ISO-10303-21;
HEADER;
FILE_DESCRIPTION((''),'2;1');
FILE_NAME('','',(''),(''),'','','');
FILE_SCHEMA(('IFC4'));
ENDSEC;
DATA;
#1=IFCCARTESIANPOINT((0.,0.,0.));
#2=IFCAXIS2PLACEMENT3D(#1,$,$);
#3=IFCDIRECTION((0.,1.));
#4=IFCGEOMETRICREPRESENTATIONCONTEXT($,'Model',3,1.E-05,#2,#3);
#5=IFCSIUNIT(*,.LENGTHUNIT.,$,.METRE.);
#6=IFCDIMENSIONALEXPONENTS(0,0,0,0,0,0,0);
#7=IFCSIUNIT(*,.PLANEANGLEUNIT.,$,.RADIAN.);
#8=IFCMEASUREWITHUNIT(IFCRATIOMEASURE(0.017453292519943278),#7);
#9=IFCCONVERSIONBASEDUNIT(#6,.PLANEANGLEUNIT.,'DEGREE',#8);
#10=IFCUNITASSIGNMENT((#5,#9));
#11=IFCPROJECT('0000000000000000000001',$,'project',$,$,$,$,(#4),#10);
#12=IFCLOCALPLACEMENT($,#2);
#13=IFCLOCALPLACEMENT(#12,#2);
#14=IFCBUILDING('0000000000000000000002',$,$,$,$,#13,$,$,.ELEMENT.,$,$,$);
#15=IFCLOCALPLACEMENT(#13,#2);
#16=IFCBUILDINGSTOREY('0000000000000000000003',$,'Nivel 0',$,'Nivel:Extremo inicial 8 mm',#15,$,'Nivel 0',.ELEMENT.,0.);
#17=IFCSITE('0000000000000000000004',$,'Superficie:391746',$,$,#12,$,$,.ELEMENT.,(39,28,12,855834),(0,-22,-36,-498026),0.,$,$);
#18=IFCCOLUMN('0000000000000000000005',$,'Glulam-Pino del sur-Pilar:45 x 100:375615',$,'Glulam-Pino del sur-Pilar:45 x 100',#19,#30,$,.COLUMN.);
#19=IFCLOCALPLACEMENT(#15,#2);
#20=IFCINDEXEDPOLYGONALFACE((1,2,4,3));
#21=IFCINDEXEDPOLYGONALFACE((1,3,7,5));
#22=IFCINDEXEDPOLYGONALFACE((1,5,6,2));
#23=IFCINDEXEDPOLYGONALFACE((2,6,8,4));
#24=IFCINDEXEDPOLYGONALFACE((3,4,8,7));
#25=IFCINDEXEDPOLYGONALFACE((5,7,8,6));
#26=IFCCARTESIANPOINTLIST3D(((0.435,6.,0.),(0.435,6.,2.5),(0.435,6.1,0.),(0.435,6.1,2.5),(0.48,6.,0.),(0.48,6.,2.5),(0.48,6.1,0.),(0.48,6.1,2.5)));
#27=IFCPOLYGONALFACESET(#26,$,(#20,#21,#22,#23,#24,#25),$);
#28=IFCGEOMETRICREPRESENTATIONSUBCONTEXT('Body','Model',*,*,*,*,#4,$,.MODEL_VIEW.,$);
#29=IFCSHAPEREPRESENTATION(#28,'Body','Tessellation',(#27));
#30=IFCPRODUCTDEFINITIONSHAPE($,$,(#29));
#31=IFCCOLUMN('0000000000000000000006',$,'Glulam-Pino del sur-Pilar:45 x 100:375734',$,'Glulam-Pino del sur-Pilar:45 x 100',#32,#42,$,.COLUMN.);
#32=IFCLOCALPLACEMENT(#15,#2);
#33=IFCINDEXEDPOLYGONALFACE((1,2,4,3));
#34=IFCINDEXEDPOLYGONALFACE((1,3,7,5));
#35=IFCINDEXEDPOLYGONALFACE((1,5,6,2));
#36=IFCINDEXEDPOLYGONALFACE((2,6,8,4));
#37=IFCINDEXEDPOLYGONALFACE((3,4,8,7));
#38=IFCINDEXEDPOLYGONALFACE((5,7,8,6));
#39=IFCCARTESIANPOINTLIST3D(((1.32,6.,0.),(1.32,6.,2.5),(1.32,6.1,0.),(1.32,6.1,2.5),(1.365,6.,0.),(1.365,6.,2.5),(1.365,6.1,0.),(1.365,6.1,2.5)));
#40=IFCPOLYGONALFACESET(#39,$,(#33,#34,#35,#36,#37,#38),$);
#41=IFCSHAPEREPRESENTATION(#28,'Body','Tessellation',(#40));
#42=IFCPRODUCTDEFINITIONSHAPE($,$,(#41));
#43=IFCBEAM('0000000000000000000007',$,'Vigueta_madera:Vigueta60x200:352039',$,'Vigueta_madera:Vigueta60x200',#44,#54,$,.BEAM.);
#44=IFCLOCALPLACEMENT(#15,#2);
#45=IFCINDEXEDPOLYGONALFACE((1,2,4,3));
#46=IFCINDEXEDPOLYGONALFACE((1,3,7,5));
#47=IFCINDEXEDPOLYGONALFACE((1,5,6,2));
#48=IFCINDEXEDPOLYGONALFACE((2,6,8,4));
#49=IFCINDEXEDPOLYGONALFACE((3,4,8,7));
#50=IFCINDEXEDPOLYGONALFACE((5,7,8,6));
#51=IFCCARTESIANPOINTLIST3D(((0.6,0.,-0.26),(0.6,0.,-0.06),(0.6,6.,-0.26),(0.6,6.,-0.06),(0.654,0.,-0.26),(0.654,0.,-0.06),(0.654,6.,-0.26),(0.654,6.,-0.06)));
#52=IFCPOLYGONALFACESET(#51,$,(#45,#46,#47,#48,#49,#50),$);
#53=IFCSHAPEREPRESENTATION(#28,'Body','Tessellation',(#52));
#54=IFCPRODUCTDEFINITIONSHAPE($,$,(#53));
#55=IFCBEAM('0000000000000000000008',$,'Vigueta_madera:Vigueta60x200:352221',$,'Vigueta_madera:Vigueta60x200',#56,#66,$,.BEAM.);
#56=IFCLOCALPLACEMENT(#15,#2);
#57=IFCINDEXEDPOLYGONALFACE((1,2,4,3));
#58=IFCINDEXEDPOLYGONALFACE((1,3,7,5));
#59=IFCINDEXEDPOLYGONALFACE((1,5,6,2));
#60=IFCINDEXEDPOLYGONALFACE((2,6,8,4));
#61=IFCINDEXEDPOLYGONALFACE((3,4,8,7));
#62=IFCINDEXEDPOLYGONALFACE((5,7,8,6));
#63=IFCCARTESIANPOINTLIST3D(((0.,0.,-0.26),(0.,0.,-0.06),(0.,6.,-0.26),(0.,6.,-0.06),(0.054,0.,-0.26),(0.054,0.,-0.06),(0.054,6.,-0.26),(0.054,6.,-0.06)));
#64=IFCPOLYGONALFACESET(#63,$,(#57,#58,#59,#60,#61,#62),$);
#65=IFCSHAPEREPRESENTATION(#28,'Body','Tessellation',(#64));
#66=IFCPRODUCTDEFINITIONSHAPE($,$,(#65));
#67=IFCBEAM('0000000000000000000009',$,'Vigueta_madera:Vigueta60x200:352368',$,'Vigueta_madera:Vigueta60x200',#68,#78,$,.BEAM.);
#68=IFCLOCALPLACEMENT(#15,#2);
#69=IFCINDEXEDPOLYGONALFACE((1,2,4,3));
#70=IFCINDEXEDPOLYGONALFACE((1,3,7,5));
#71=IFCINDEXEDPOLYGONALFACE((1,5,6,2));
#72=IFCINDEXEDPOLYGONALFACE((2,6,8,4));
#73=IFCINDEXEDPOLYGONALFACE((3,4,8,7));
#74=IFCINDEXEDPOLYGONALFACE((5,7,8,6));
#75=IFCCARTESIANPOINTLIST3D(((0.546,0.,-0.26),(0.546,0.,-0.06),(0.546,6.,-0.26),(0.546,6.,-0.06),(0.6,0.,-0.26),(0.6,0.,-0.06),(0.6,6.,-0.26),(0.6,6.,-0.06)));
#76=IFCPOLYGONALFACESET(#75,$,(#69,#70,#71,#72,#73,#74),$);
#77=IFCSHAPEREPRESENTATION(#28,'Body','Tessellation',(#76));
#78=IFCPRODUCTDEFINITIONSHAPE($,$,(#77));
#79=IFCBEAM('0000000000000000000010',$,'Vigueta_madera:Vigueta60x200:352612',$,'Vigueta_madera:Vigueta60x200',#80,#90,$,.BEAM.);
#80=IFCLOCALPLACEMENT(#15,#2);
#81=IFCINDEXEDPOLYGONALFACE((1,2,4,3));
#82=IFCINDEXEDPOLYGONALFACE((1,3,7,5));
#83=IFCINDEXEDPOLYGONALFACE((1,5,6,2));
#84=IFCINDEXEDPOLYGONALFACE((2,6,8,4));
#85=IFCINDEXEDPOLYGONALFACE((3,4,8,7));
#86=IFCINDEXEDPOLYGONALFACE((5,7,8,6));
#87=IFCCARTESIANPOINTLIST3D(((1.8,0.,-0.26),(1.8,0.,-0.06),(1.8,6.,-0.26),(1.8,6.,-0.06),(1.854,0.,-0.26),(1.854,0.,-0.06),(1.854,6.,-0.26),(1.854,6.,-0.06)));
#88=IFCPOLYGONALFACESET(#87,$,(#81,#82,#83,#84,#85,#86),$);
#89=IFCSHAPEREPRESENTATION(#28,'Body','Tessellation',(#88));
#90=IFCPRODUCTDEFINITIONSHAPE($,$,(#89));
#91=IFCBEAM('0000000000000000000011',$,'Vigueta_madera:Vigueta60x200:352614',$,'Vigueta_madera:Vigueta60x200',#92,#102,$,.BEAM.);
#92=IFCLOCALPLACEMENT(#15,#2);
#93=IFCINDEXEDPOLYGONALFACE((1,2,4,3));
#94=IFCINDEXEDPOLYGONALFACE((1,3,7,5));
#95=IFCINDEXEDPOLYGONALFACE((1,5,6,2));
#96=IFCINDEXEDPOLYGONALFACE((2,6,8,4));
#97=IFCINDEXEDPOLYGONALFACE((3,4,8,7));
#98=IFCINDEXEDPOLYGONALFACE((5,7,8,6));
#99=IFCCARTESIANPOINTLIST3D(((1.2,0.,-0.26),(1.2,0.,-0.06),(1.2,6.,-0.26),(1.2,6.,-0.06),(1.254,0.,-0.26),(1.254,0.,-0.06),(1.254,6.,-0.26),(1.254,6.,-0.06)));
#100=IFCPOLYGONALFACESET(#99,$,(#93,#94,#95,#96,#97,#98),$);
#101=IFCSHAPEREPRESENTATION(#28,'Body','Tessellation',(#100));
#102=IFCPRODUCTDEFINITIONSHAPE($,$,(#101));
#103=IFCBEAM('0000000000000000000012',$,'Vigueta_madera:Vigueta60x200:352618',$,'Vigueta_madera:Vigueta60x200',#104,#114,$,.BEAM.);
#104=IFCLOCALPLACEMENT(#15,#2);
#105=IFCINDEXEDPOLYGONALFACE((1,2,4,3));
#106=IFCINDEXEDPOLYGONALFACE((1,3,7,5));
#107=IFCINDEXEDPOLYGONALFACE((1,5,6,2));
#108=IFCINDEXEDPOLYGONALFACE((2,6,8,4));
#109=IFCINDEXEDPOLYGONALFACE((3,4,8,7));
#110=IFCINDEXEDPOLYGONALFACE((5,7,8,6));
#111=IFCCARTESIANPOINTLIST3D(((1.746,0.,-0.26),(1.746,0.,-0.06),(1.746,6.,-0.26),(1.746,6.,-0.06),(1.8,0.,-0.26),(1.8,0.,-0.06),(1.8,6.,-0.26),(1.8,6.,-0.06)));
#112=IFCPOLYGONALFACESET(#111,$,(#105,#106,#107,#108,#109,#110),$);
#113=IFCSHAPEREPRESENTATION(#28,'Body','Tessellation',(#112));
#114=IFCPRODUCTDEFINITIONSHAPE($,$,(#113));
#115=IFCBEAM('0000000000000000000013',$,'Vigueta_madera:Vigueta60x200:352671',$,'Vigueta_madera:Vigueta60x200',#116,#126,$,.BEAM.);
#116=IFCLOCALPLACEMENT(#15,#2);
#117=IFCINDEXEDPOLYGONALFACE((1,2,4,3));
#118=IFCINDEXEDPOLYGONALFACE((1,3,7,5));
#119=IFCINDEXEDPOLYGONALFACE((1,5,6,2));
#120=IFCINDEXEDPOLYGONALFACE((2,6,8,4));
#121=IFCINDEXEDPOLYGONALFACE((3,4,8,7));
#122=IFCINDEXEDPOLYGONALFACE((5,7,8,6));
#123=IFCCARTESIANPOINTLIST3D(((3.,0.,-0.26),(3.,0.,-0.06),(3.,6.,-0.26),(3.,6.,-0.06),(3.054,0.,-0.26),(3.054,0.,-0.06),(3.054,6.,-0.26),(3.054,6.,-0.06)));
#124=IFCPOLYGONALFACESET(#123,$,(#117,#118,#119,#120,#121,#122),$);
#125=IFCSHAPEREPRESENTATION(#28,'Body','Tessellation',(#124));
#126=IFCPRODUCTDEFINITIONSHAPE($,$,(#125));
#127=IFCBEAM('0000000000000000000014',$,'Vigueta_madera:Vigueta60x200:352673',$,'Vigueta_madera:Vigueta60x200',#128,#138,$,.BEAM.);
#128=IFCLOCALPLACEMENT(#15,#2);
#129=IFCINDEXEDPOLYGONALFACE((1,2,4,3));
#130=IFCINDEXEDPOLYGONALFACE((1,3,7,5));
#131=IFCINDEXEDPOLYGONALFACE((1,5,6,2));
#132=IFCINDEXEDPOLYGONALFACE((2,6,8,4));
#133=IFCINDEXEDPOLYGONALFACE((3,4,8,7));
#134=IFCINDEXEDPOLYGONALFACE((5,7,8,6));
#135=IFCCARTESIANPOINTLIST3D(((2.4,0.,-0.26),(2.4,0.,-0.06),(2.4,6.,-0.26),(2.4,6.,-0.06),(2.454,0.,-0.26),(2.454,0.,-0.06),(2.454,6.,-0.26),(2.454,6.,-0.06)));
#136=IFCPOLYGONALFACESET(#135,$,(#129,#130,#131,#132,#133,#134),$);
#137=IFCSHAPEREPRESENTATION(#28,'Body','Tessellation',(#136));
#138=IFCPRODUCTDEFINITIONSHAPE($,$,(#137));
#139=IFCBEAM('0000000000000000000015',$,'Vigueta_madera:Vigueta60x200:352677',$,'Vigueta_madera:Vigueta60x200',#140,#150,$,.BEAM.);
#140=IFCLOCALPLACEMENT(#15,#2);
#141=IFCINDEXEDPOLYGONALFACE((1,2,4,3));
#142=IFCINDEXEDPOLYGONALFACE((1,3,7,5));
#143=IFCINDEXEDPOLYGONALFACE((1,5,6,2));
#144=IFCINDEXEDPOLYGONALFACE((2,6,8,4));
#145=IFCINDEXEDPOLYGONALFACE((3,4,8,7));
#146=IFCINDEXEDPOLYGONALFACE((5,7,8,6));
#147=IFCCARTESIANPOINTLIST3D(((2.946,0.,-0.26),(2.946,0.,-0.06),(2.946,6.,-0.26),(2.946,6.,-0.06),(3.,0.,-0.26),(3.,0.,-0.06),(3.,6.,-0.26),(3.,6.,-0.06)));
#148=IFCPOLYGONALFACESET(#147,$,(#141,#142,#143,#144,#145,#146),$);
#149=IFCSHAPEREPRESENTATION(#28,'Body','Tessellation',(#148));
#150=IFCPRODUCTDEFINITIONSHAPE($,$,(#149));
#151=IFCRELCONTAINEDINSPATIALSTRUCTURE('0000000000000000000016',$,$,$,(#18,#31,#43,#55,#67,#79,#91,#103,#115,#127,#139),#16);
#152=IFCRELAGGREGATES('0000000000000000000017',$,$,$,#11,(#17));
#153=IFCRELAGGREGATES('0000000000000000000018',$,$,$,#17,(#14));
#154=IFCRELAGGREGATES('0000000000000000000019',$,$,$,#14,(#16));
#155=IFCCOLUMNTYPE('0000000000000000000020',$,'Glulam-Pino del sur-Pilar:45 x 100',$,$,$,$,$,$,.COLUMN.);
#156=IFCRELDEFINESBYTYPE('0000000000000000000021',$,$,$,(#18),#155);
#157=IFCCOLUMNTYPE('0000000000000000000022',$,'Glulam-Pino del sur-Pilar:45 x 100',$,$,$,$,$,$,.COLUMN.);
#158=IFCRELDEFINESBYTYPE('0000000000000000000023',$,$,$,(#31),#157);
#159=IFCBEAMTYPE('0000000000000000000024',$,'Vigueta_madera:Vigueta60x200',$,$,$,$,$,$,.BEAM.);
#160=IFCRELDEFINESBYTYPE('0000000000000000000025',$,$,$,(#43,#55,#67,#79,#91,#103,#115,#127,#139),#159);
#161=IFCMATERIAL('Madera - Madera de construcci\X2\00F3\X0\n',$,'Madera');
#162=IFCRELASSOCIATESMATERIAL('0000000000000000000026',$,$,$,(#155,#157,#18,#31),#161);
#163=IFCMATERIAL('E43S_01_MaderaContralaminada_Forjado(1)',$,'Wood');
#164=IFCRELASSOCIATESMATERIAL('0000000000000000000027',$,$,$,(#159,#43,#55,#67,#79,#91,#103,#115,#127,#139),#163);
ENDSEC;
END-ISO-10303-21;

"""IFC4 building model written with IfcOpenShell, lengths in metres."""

from ifc_helpers import new_model, entity, si_unit, converted_unit, direction, frame, origin, origin_2d_with_axis, place, context, subcontext, project, spatial, polyline, segment, composite_curve, rectangle, outline, extrude, source, transform, mapped, material, material_profile, profile_set, profile_usage, type_object, type_shapes, element, save


model = new_model("IFC4")

# Units and contexts
model_context = context("Model", 3, precision=1e-05, world=origin(), true_north=direction((0.0, 1.0)))
body_context = subcontext(model_context, "Body", "Model", "MODEL_VIEW")
ifc_project = project(units=[si_unit("LENGTHUNIT", "METRE"), converted_unit("PLANEANGLEUNIT", "DEGREE", entity("IfcRatioMeasure", 0.017453292519943278), si_unit("PLANEANGLEUNIT", "RADIAN"), dimensions=[0, 0, 0, 0, 0, 0, 0])], contexts=[model_context])

# Site, building, storey
site_placement = place(None, origin())
site = spatial("IfcSite", under=ifc_project, at=site_placement, Name="Superficie:391746", CompositionType="ELEMENT", RefLatitude=(39, 28, 12, 855834), RefLongitude=(0, -22, -36, -498026), RefElevation=0.0)
building_placement = place(site_placement, origin())
building = spatial("IfcBuilding", under=site, at=building_placement, CompositionType="ELEMENT")
storey_placement = place(building_placement, origin())
storey = spatial("IfcBuildingStorey", under=building, at=storey_placement, Name="Nivel 0", ObjectType="Nivel:Extremo inicial 8 mm", LongName="Nivel 0", CompositionType="ELEMENT", Elevation=0.0)

# Columns
ifc_material_1 = material(Name="Madera - Madera de construcción", Category="Madera")
ifc_material_profile_1 = material_profile(ifc_material_1, outline(composite_curve([segment(polyline([(0.0225, 0.05, 0.0), (0.0225, -0.05, 0.0)]), True, "CONTINUOUS"), segment(polyline([(0.0225, -0.05, 0.0), (-0.0225, -0.05, 0.0)]), True, "CONTINUOUS"), segment(polyline([(-0.0225, -0.05, 0.0), (-0.0225, 0.05, 0.0)]), True, "CONTINUOUS"), segment(polyline([(-0.0225, 0.05, 0.0), (0.0225, 0.05, 0.0)]), True, "CONTINUOUS")], self_intersect=False), kind="CURVE"), Name="45 x 100")
ifc_material_profile_2 = material_profile(ifc_material_1, outline(composite_curve([segment(polyline([(0.0225, 0.05, 2.5), (-0.0225, 0.05, 2.5)]), True, "CONTINUOUS"), segment(polyline([(-0.0225, 0.05, 2.5), (-0.0225, -0.05, 2.5)]), True, "CONTINUOUS"), segment(polyline([(-0.0225, -0.05, 2.5), (0.0225, -0.05, 2.5)]), True, "CONTINUOUS"), segment(polyline([(0.0225, -0.05, 2.5), (0.0225, 0.05, 2.5)]), True, "CONTINUOUS")], self_intersect=False), kind="CURVE"), Name="45 x 100")
ifc_profile_set_1 = profile_set([ifc_material_profile_1, ifc_material_profile_2], Name="45 x 100")
ifc_profile_usage_1 = profile_usage(ifc_profile_set_1)
column_type_1 = type_object("IfcColumnType", Name="Glulam-Pino del sur-Pilar:45 x 100", PredefinedType="COLUMN", material=ifc_profile_set_1)
shared_shape_1 = source(origin(), body_context, "Body", "SweptSolid", [
    extrude(rectangle(XDim=0.1, YDim=0.045, at=origin_2d_with_axis()), frame((0.0, 0.0, 0.0), z_axis=(0.0, 0.0, 1.0), x_axis=(0.0, -1.0, 0.0)), (0.0, 0.0, 1.0), 2.5),
])
type_shapes(column_type_1, [shared_shape_1])
column_1_placement = place(storey_placement, frame((0.4575, 6.05, 0.0)))
element("IfcColumn", 1, at=column_1_placement, inside=storey, type_object=column_type_1, material=ifc_profile_usage_1, Name="Glulam-Pino del sur-Pilar:45 x 100:375615", ObjectType="Glulam-Pino del sur-Pilar:45 x 100", PredefinedType="COLUMN", context=body_context, shape_type="MappedRepresentation", body=[
    mapped(shared_shape_1, transform((0.0, 0.0, 0.0), scale=1.0)),
])
ifc_profile_usage_2 = profile_usage(ifc_profile_set_1)
column_type_2 = type_object("IfcColumnType", Name="Glulam-Pino del sur-Pilar:45 x 100", PredefinedType="COLUMN", material=ifc_profile_set_1)
shared_shape_2 = source(origin(), body_context, "Body", "SweptSolid", [
    extrude(rectangle(XDim=0.1, YDim=0.045, at=origin_2d_with_axis()), frame((0.0, 0.0, 0.0), z_axis=(0.0, 0.0, 1.0), x_axis=(0.0, -1.0, 0.0)), (0.0, 0.0, 1.0), 2.5),
])
type_shapes(column_type_2, [shared_shape_2])
column_2_placement = place(storey_placement, frame((1.3425, 6.05, 0.0), z_axis=(0.0, 0.0, 1.0), x_axis=(-1.0, 0.0, 0.0)))
element("IfcColumn", 2, at=column_2_placement, inside=storey, type_object=column_type_2, material=ifc_profile_usage_2, Name="Glulam-Pino del sur-Pilar:45 x 100:375734", ObjectType="Glulam-Pino del sur-Pilar:45 x 100", PredefinedType="COLUMN", context=body_context, shape_type="MappedRepresentation", body=[
    mapped(shared_shape_2, transform((0.0, 0.0, 0.0), scale=1.0)),
])

# Beams
ifc_material_2 = material(Name="E43S_01_MaderaContralaminada_Forjado(1)", Category="Wood")
ifc_material_profile_3 = material_profile(ifc_material_2, outline(composite_curve([segment(polyline([(-0.027, -0.1, 0.0), (-0.027, 0.1, 0.0)]), True, "CONTINUOUS"), segment(polyline([(-0.027, 0.1, 0.0), (0.027, 0.1, 0.0)]), True, "CONTINUOUS"), segment(polyline([(0.027, 0.1, 0.0), (0.027, -0.1, 0.0)]), True, "CONTINUOUS"), segment(polyline([(0.027, -0.1, 0.0), (-0.027, -0.1, 0.0)]), True, "CONTINUOUS")], self_intersect=False), kind="CURVE"), Name="Vigueta60x200")
ifc_material_profile_4 = material_profile(ifc_material_2, outline(composite_curve([segment(polyline([(3.0, 0.027, 0.1), (3.0, 0.027, -0.1)]), True, "CONTINUOUS"), segment(polyline([(3.0, 0.027, -0.1), (-3.0, 0.027, -0.1)]), True, "CONTINUOUS"), segment(polyline([(-3.0, 0.027, -0.1), (-3.0, 0.027, 0.1)]), True, "CONTINUOUS"), segment(polyline([(-3.0, 0.027, 0.1), (3.0, 0.027, 0.1)]), True, "CONTINUOUS")], self_intersect=False), kind="CURVE"), Name="Vigueta60x200")
ifc_profile_set_2 = profile_set([ifc_material_profile_3, ifc_material_profile_4], Name="Vigueta60x200")
ifc_profile_usage_3 = profile_usage(ifc_profile_set_2, cardinal=8)
beam_type_1 = type_object("IfcBeamType", Name="Vigueta_madera:Vigueta60x200", PredefinedType="BEAM", material=ifc_profile_set_2)
shared_shape_3 = source(origin(), body_context, "Body", "SweptSolid", [
    extrude(rectangle(XDim=0.2, YDim=0.054, at=origin_2d_with_axis()), frame((-3.0, 0.0, 0.0), z_axis=(1.0, 0.0, 0.0), x_axis=(0.0, 0.0, -1.0)), (0.0, 0.0, 1.0), 6.0),
])
type_shapes(beam_type_1, [shared_shape_3])
beam_1_placement = place(storey_placement, frame((0.627, 3.0, -0.16), z_axis=(0.0, 0.0, 1.0), x_axis=(0.0, 1.0, 0.0)))
element("IfcBeam", 3, at=beam_1_placement, inside=storey, type_object=beam_type_1, material=ifc_profile_usage_3, Name="Vigueta_madera:Vigueta60x200:352039", ObjectType="Vigueta_madera:Vigueta60x200", PredefinedType="BEAM", context=body_context, shape_type="MappedRepresentation", body=[
    mapped(shared_shape_3, transform((0.0, 0.0, 0.0), scale=1.0)),
])
ifc_profile_usage_4 = profile_usage(ifc_profile_set_2, cardinal=8)
beam_2_placement = place(storey_placement, frame((0.027, 3.0, -0.16), z_axis=(0.0, 0.0, 1.0), x_axis=(0.0, 1.0, 0.0)))
element("IfcBeam", 4, at=beam_2_placement, inside=storey, type_object=beam_type_1, material=ifc_profile_usage_4, Name="Vigueta_madera:Vigueta60x200:352221", ObjectType="Vigueta_madera:Vigueta60x200", PredefinedType="BEAM", context=body_context, shape_type="MappedRepresentation", body=[
    mapped(shared_shape_3, transform((0.0, 0.0, 0.0), scale=1.0)),
])
ifc_profile_usage_5 = profile_usage(ifc_profile_set_2, cardinal=8)
beam_3_placement = place(storey_placement, frame((0.573, 3.0, -0.16), z_axis=(0.0, 0.0, 1.0), x_axis=(0.0, 1.0, 0.0)))
element("IfcBeam", 5, at=beam_3_placement, inside=storey, type_object=beam_type_1, material=ifc_profile_usage_5, Name="Vigueta_madera:Vigueta60x200:352368", ObjectType="Vigueta_madera:Vigueta60x200", PredefinedType="BEAM", context=body_context, shape_type="MappedRepresentation", body=[
    mapped(shared_shape_3, transform((0.0, 0.0, 0.0), scale=1.0)),
])
ifc_profile_usage_6 = profile_usage(ifc_profile_set_2, cardinal=8)
beam_4_placement = place(storey_placement, frame((1.827, 3.0, -0.16), z_axis=(0.0, 0.0, 1.0), x_axis=(0.0, 1.0, 0.0)))
element("IfcBeam", 6, at=beam_4_placement, inside=storey, type_object=beam_type_1, material=ifc_profile_usage_6, Name="Vigueta_madera:Vigueta60x200:352612", ObjectType="Vigueta_madera:Vigueta60x200", PredefinedType="BEAM", context=body_context, shape_type="MappedRepresentation", body=[
    mapped(shared_shape_3, transform((0.0, 0.0, 0.0), scale=1.0)),
])
ifc_profile_usage_7 = profile_usage(ifc_profile_set_2, cardinal=8)
beam_5_placement = place(storey_placement, frame((1.227, 3.0, -0.16), z_axis=(0.0, 0.0, 1.0), x_axis=(0.0, 1.0, 0.0)))
element("IfcBeam", 7, at=beam_5_placement, inside=storey, type_object=beam_type_1, material=ifc_profile_usage_7, Name="Vigueta_madera:Vigueta60x200:352614", ObjectType="Vigueta_madera:Vigueta60x200", PredefinedType="BEAM", context=body_context, shape_type="MappedRepresentation", body=[
    mapped(shared_shape_3, transform((0.0, 0.0, 0.0), scale=1.0)),
])
ifc_profile_usage_8 = profile_usage(ifc_profile_set_2, cardinal=8)
beam_6_placement = place(storey_placement, frame((1.773, 3.0, -0.16), z_axis=(0.0, 0.0, 1.0), x_axis=(0.0, 1.0, 0.0)))
element("IfcBeam", 8, at=beam_6_placement, inside=storey, type_object=beam_type_1, material=ifc_profile_usage_8, Name="Vigueta_madera:Vigueta60x200:352618", ObjectType="Vigueta_madera:Vigueta60x200", PredefinedType="BEAM", context=body_context, shape_type="MappedRepresentation", body=[
    mapped(shared_shape_3, transform((0.0, 0.0, 0.0), scale=1.0)),
])
ifc_profile_usage_9 = profile_usage(ifc_profile_set_2, cardinal=8)
beam_7_placement = place(storey_placement, frame((3.027, 3.0, -0.16), z_axis=(0.0, 0.0, 1.0), x_axis=(0.0, 1.0, 0.0)))
element("IfcBeam", 9, at=beam_7_placement, inside=storey, type_object=beam_type_1, material=ifc_profile_usage_9, Name="Vigueta_madera:Vigueta60x200:352671", ObjectType="Vigueta_madera:Vigueta60x200", PredefinedType="BEAM", context=body_context, shape_type="MappedRepresentation", body=[
    mapped(shared_shape_3, transform((0.0, 0.0, 0.0), scale=1.0)),
])
ifc_profile_usage_10 = profile_usage(ifc_profile_set_2, cardinal=8)
beam_8_placement = place(storey_placement, frame((2.427, 3.0, -0.16), z_axis=(0.0, 0.0, 1.0), x_axis=(0.0, 1.0, 0.0)))
element("IfcBeam", 10, at=beam_8_placement, inside=storey, type_object=beam_type_1, material=ifc_profile_usage_10, Name="Vigueta_madera:Vigueta60x200:352673", ObjectType="Vigueta_madera:Vigueta60x200", PredefinedType="BEAM", context=body_context, shape_type="MappedRepresentation", body=[
    mapped(shared_shape_3, transform((0.0, 0.0, 0.0), scale=1.0)),
])
ifc_profile_usage_11 = profile_usage(ifc_profile_set_2, cardinal=8)
beam_9_placement = place(storey_placement, frame((2.973, 3.0, -0.16), z_axis=(0.0, 0.0, 1.0), x_axis=(0.0, 1.0, 0.0)))
element("IfcBeam", 11, at=beam_9_placement, inside=storey, type_object=beam_type_1, material=ifc_profile_usage_11, Name="Vigueta_madera:Vigueta60x200:352677", ObjectType="Vigueta_madera:Vigueta60x200", PredefinedType="BEAM", context=body_context, shape_type="MappedRepresentation", body=[
    mapped(shared_shape_3, transform((0.0, 0.0, 0.0), scale=1.0)),
])

save(model, "model.ifc")
